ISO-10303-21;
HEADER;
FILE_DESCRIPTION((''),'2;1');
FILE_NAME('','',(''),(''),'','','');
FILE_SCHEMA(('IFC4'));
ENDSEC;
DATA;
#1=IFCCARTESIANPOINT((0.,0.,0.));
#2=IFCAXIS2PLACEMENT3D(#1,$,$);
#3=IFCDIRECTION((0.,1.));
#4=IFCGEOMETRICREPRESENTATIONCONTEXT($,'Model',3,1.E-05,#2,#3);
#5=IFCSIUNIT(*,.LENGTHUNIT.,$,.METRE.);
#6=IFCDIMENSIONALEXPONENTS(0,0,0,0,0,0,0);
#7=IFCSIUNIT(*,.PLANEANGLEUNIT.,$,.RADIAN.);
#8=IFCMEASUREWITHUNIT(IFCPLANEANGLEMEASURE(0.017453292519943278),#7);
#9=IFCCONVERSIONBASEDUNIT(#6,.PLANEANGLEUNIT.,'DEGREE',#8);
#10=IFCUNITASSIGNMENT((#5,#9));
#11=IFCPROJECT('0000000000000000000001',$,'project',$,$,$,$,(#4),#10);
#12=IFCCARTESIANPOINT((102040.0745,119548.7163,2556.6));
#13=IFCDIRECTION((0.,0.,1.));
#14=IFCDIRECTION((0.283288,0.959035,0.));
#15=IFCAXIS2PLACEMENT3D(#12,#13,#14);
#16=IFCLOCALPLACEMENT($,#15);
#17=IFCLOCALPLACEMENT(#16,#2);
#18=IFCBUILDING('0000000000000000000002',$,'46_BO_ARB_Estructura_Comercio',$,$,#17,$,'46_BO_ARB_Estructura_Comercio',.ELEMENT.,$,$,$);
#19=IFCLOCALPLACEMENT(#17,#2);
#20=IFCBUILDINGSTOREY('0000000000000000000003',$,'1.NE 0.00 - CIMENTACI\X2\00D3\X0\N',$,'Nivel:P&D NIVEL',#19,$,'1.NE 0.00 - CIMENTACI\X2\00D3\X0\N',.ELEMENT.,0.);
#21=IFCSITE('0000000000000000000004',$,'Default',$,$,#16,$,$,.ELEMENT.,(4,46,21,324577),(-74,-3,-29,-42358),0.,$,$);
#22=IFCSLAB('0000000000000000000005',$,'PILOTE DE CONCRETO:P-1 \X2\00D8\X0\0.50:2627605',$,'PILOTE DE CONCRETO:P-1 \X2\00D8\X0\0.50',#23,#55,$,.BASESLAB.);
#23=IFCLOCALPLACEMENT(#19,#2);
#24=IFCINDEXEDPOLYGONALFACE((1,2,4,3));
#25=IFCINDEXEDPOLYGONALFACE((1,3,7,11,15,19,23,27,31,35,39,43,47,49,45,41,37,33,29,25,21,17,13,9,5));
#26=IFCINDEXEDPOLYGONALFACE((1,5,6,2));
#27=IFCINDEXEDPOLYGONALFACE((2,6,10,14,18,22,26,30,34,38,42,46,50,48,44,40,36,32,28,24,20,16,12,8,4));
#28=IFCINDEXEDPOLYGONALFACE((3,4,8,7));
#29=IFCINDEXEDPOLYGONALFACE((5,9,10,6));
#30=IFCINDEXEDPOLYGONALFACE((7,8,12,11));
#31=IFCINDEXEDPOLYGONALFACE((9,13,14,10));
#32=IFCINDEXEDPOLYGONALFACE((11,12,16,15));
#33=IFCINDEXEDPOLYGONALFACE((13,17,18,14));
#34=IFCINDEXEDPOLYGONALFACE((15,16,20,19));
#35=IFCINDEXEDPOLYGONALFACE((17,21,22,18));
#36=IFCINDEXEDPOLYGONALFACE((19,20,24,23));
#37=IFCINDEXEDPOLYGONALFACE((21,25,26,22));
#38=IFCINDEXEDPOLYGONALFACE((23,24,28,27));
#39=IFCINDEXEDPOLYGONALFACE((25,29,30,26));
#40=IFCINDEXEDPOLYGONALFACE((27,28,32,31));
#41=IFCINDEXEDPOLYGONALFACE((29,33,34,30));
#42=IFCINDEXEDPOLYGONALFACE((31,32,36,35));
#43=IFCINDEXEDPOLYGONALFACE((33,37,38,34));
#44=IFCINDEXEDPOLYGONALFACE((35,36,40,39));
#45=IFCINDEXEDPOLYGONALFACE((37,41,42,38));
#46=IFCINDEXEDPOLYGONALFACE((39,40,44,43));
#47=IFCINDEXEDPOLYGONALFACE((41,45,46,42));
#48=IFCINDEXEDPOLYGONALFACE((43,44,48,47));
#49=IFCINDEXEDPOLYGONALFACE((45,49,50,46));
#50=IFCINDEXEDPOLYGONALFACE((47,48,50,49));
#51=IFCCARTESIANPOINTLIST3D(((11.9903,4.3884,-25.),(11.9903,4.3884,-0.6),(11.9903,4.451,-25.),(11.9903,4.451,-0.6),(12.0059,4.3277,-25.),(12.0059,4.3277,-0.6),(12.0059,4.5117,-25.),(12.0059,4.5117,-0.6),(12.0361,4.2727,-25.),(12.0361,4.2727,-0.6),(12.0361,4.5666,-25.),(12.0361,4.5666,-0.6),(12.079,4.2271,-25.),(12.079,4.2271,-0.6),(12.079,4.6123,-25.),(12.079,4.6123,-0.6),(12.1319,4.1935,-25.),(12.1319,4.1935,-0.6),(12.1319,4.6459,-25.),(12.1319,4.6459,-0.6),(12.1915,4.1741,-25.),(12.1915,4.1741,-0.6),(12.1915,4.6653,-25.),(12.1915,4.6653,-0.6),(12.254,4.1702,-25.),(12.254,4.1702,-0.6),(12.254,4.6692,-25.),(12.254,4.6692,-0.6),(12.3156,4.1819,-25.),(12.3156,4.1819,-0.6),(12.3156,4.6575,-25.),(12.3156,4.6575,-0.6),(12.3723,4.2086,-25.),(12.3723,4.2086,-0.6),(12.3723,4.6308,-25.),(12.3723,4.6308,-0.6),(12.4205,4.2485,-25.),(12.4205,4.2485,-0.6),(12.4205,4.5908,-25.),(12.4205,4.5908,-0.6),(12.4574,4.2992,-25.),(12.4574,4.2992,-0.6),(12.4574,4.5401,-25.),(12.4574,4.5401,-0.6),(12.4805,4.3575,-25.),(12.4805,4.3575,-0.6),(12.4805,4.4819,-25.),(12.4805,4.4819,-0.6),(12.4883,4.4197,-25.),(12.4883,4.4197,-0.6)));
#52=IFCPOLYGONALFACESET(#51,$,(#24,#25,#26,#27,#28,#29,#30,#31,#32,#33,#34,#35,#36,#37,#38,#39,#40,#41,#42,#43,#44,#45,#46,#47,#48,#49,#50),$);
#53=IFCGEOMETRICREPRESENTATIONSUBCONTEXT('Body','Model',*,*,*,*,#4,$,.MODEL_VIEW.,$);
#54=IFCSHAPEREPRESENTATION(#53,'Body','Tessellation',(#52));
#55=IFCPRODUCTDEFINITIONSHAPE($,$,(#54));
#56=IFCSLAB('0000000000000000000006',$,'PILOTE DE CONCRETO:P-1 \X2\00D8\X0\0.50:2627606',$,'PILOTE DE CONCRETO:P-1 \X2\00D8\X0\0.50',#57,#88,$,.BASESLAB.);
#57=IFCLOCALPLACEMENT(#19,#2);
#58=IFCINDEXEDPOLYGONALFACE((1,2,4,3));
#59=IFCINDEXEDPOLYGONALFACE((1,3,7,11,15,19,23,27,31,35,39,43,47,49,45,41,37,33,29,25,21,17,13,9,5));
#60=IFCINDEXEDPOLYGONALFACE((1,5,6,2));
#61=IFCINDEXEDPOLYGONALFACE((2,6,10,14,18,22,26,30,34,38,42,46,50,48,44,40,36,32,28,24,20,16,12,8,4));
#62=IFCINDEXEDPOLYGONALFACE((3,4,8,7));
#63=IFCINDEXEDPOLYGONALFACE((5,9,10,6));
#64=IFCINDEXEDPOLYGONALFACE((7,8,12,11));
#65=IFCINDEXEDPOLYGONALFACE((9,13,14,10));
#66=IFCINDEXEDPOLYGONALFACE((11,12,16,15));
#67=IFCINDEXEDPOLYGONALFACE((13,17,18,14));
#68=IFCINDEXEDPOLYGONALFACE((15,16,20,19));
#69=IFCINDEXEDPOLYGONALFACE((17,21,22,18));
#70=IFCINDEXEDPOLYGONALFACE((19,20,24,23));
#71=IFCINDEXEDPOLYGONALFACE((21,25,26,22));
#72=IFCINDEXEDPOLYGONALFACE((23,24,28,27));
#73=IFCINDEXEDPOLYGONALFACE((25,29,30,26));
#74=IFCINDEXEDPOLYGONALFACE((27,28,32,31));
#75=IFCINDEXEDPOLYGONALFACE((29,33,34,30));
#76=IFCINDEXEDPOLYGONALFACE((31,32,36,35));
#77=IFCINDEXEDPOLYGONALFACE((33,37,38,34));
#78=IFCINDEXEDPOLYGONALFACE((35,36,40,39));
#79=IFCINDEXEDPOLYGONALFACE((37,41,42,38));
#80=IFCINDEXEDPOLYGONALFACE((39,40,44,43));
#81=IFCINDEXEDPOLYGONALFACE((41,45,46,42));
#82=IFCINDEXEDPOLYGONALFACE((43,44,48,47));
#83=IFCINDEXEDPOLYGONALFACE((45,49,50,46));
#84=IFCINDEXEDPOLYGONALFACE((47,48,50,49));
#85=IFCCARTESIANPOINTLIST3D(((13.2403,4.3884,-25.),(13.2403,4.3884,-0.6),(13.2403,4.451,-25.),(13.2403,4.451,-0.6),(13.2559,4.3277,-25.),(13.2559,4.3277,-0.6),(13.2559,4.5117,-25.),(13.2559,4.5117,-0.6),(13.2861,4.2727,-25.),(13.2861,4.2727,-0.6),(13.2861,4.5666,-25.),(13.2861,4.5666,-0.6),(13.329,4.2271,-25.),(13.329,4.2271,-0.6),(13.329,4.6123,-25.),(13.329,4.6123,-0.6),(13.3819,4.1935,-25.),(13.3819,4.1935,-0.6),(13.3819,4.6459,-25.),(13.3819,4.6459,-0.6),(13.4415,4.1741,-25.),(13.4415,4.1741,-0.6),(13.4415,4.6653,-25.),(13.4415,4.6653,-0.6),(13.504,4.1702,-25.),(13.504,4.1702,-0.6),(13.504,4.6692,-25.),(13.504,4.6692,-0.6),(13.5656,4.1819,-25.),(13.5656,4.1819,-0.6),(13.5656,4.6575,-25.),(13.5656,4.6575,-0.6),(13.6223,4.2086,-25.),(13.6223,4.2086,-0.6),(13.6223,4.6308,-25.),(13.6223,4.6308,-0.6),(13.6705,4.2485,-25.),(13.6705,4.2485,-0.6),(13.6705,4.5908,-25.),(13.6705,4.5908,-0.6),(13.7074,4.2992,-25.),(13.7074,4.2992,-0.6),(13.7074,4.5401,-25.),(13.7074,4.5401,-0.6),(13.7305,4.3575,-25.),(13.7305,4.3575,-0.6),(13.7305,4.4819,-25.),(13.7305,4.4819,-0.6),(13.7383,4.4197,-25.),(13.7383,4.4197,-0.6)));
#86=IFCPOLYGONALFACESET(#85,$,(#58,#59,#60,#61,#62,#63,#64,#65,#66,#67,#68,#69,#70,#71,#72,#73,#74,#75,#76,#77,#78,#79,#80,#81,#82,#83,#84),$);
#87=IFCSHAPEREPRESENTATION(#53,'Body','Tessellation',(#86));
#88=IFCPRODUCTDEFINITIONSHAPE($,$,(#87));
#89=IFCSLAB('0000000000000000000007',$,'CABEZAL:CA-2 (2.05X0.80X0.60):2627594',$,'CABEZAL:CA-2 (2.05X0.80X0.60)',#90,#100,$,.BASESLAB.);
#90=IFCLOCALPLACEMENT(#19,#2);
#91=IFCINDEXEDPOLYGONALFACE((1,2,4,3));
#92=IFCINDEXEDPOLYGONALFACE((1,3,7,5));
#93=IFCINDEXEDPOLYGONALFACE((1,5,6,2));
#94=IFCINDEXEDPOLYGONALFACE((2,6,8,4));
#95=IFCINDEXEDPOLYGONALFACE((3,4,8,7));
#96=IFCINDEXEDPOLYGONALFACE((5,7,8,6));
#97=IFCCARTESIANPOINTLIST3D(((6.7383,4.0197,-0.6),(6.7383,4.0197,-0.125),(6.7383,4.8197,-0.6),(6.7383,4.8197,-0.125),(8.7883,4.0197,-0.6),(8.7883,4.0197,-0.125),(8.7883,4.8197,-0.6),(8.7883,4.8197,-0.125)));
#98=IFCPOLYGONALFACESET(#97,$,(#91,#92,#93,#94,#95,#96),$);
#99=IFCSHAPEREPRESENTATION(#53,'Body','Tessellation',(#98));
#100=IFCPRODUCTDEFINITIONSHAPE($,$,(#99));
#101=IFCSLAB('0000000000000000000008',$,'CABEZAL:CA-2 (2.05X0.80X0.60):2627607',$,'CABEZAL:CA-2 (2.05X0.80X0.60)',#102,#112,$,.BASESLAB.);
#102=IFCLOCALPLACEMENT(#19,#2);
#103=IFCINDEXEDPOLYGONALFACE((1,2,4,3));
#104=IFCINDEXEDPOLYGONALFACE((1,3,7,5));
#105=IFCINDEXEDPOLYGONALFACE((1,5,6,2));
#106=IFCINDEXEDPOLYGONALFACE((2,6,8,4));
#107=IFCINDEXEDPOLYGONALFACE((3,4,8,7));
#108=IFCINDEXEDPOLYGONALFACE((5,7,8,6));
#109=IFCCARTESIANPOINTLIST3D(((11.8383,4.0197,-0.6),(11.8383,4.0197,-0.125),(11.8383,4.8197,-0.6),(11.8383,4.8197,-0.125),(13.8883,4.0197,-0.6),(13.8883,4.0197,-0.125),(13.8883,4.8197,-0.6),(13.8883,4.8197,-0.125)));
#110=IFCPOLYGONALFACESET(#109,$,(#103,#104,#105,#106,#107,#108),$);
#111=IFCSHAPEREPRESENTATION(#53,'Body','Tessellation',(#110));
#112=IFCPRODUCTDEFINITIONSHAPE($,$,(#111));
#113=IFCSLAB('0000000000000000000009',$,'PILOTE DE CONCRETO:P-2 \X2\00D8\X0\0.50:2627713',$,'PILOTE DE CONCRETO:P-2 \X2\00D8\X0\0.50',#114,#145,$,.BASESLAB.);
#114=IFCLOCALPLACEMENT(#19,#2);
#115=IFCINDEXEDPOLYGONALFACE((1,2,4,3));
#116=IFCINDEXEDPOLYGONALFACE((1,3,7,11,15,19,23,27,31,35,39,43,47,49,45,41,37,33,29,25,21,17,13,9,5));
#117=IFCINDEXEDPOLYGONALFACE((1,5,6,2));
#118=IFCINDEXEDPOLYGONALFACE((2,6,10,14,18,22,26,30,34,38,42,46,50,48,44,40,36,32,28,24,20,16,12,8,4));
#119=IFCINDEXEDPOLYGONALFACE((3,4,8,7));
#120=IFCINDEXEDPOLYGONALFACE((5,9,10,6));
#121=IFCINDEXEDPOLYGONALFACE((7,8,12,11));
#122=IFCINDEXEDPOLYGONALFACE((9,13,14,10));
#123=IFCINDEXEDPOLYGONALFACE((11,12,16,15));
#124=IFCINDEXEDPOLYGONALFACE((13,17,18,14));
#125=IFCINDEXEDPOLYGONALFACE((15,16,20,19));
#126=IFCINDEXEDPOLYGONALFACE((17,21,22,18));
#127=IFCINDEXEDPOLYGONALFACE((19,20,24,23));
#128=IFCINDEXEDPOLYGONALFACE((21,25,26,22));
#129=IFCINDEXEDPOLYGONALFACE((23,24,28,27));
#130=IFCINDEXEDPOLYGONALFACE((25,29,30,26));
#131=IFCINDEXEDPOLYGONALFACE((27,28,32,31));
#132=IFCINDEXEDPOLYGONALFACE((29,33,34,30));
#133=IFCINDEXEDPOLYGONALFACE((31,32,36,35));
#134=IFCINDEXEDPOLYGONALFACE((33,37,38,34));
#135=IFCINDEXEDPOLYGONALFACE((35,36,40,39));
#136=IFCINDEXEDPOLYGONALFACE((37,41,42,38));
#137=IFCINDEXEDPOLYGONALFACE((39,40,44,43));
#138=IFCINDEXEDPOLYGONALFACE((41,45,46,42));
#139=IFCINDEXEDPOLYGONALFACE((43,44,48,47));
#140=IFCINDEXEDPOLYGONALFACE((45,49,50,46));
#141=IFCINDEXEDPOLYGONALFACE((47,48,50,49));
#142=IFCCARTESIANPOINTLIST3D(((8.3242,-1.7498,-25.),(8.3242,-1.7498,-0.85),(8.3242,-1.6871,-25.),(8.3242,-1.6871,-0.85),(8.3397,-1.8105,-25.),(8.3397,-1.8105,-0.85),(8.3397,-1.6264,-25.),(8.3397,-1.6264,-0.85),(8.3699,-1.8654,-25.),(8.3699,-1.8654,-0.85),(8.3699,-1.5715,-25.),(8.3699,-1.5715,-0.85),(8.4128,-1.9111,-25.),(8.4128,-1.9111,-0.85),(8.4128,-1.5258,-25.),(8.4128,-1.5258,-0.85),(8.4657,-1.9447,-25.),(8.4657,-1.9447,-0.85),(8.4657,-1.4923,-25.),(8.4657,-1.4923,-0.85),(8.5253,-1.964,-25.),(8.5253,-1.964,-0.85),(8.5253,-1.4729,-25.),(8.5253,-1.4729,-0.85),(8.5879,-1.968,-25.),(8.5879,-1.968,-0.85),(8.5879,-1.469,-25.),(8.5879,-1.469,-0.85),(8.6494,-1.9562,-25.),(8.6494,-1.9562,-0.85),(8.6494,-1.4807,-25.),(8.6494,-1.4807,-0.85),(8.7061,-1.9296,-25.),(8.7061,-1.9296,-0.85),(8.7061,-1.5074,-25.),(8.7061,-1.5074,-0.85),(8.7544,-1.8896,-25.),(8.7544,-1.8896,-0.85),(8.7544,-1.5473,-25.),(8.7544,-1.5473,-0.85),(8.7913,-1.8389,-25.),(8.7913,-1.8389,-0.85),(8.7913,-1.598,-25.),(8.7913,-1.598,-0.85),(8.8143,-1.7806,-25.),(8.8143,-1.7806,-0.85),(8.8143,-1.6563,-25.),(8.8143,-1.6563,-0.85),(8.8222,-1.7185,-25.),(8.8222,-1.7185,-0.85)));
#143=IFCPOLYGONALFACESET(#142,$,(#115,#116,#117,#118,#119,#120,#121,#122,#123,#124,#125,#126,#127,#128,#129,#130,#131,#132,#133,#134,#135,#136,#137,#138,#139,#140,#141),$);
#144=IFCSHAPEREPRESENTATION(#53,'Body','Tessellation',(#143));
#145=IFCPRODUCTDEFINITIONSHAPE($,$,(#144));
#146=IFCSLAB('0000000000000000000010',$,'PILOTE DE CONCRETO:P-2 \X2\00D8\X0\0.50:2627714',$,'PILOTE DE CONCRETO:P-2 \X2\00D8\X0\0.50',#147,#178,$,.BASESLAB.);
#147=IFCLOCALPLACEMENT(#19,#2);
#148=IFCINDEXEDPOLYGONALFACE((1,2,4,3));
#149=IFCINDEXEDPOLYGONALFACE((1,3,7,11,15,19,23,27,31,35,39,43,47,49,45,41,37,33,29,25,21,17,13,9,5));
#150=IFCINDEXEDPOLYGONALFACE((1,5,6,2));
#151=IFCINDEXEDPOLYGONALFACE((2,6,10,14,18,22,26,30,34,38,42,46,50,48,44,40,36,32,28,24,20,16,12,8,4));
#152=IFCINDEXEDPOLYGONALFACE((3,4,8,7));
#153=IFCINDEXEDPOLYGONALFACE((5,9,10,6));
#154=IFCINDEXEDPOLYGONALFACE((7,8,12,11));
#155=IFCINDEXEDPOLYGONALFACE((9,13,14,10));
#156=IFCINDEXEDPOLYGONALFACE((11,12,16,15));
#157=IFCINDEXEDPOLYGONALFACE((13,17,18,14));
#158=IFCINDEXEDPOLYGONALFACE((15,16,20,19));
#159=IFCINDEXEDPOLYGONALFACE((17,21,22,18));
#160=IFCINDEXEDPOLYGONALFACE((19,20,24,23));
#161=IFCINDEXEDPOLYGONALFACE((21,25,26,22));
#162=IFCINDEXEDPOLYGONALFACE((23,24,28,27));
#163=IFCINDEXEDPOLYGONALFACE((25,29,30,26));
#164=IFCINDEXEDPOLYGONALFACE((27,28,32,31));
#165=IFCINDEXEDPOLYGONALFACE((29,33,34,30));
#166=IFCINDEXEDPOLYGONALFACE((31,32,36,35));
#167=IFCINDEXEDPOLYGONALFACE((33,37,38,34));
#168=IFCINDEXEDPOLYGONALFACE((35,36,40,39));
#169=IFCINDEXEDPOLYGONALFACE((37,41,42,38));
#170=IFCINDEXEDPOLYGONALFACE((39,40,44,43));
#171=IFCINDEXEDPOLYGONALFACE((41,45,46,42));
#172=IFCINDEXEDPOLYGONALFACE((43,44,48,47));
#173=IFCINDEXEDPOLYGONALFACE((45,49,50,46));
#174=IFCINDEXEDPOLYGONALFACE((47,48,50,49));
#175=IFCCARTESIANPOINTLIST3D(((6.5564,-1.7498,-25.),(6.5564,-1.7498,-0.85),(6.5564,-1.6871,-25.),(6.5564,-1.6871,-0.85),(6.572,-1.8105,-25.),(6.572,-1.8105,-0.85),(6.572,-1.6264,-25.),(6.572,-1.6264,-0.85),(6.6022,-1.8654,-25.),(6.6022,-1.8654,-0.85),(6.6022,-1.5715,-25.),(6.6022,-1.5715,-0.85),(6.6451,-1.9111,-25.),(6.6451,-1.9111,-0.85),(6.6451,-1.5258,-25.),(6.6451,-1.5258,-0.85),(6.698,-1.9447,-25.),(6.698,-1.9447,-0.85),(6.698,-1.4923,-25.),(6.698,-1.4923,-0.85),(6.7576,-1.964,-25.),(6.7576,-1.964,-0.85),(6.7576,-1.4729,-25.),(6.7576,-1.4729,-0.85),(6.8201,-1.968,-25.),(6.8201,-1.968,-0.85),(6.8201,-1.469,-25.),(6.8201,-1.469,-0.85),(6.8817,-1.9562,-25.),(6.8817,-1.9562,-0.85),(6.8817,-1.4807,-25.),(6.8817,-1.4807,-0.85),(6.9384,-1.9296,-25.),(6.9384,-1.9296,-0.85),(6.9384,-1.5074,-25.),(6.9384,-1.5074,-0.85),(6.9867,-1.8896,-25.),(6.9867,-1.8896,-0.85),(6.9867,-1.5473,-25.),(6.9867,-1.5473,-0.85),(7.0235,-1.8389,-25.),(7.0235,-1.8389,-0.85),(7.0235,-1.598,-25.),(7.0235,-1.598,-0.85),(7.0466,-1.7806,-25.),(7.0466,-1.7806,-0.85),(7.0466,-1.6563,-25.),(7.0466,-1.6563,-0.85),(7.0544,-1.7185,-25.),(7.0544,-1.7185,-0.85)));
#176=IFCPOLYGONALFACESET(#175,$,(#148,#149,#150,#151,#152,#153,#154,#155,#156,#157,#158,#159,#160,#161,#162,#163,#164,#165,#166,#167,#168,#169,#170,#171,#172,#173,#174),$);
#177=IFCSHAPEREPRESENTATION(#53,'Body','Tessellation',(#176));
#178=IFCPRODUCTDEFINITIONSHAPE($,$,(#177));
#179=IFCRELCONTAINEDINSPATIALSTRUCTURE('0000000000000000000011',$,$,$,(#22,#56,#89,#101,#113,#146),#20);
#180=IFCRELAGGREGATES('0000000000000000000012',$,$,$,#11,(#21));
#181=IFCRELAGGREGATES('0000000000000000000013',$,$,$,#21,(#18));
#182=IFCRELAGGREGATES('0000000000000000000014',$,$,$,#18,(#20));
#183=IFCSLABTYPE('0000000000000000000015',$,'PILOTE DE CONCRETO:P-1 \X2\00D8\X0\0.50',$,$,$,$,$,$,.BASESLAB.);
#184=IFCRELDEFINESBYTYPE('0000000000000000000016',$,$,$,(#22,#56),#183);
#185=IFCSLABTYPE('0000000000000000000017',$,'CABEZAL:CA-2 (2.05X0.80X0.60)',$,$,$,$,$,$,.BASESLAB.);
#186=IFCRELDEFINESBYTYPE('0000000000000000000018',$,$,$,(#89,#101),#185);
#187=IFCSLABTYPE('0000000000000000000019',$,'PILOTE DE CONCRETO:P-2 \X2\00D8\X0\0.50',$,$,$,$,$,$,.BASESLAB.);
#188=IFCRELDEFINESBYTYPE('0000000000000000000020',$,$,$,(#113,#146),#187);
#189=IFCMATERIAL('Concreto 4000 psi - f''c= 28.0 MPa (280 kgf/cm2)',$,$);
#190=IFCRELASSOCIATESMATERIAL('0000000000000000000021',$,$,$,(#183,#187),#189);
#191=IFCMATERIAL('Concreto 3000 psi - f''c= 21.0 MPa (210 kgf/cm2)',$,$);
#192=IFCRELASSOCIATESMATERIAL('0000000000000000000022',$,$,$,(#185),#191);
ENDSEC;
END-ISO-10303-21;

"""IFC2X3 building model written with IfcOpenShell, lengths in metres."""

from ifc_helpers import new_model, entity, si_unit, converted_unit, direction, frame, frame_2d, origin, origin_2d_with_axis, place, context, subcontext, project, spatial, rectangle, circle, extrude, material, type_object, element, save


model = new_model("IFC2X3")

# Units and contexts
model_context = context("Model", 3, precision=1e-05, world=origin(), true_north=direction((0.0, 1.0)))
body_context = subcontext(model_context, "Body", "Model", "MODEL_VIEW")
ifc_project = project(units=[si_unit("LENGTHUNIT", "METRE"), converted_unit("PLANEANGLEUNIT", "DEGREE", entity("IfcPlaneAngleMeasure", 0.017453292519943278), si_unit("PLANEANGLEUNIT", "RADIAN"), dimensions=[0, 0, 0, 0, 0, 0, 0])], contexts=[model_context])

# Site, building, storey
site_placement = place(None, frame((102040.0745, 119548.7163, 2556.6), z_axis=(0.0, 0.0, 1.0), x_axis=(0.283288, 0.959035, 0.0)))
site = spatial("IfcSite", under=ifc_project, at=site_placement, Name="Default", CompositionType="ELEMENT", RefLatitude=(4, 46, 21, 324577), RefLongitude=(-74, -3, -29, -42358), RefElevation=0.0)
building_placement = place(site_placement, origin())
building = spatial("IfcBuilding", under=site, at=building_placement, Name="46_BO_ARB_Estructura_Comercio", LongName="46_BO_ARB_Estructura_Comercio", CompositionType="ELEMENT")
storey_placement = place(building_placement, origin())
storey = spatial("IfcBuildingStorey", under=building, at=storey_placement, Name="1.NE 0.00 - CIMENTACIÓN", ObjectType="Nivel:P&D NIVEL", LongName="1.NE 0.00 - CIMENTACIÓN", CompositionType="ELEMENT", Elevation=0.0)

# Shared definitions
ifc_material_1 = material(Name="Concreto 4000 psi - f'c= 28.0 MPa (280 kgf/cm2)")

# Shared definitions
ifc_material_2 = material(Name="Concreto 3000 psi - f'c= 21.0 MPa (210 kgf/cm2)")

# Slabs
slab_type_1 = type_object("IfcSlabType", Name="PILOTE DE CONCRETO:P-1 Ø0.50", PredefinedType="BASESLAB", material=ifc_material_1)
slab_1_placement = place(storey_placement, origin())
element("IfcSlab", 1, at=slab_1_placement, inside=storey, type_object=slab_type_1, Name="PILOTE DE CONCRETO:P-1 Ø0.50:2627605", ObjectType="PILOTE DE CONCRETO:P-1 Ø0.50", PredefinedType="BASESLAB", context=body_context, shape_type="SweptSolid", body=[
    extrude(circle(Radius=0.25, at=frame_2d((0.0, 0.0), x_axis=(1.0, 0.0))), frame((12.2383, 4.4197, -25.0)), (0.0, 0.0, 1.0), 24.4),
])
slab_2_placement = place(storey_placement, origin())
element("IfcSlab", 2, at=slab_2_placement, inside=storey, type_object=slab_type_1, Name="PILOTE DE CONCRETO:P-1 Ø0.50:2627606", ObjectType="PILOTE DE CONCRETO:P-1 Ø0.50", PredefinedType="BASESLAB", context=body_context, shape_type="SweptSolid", body=[
    extrude(circle(Radius=0.25, at=frame_2d((0.0, 0.0), x_axis=(1.0, 0.0))), frame((13.4883, 4.4197, -25.0)), (0.0, 0.0, 1.0), 24.4),
])
slab_type_2 = type_object("IfcSlabType", Name="CABEZAL:CA-2 (2.05X0.80X0.60)", PredefinedType="BASESLAB", material=ifc_material_2)
slab_3_placement = place(storey_placement, origin())
element("IfcSlab", 3, at=slab_3_placement, inside=storey, type_object=slab_type_2, Name="CABEZAL:CA-2 (2.05X0.80X0.60):2627594", ObjectType="CABEZAL:CA-2 (2.05X0.80X0.60)", PredefinedType="BASESLAB", context=body_context, shape_type="SweptSolid", body=[
    extrude(rectangle(XDim=2.05, YDim=0.8, at=origin_2d_with_axis()), frame((7.7633, 4.4197, -0.6), z_axis=(0.0, 0.0, 1.0), x_axis=(-1.0, 0.0, 0.0)), (0.0, 0.0, 1.0), 0.475),
])
slab_4_placement = place(storey_placement, origin())
element("IfcSlab", 4, at=slab_4_placement, inside=storey, type_object=slab_type_2, Name="CABEZAL:CA-2 (2.05X0.80X0.60):2627607", ObjectType="CABEZAL:CA-2 (2.05X0.80X0.60)", PredefinedType="BASESLAB", context=body_context, shape_type="SweptSolid", body=[
    extrude(rectangle(XDim=2.05, YDim=0.8, at=frame_2d((0.0, 0.0), x_axis=(1.0, 0.0))), frame((12.8633, 4.4197, -0.6), z_axis=(0.0, 0.0, 1.0), x_axis=(-1.0, 0.0, 0.0)), (0.0, 0.0, 1.0), 0.475),
])
slab_type_3 = type_object("IfcSlabType", Name="PILOTE DE CONCRETO:P-2 Ø0.50", PredefinedType="BASESLAB", material=ifc_material_1)
slab_5_placement = place(storey_placement, origin())
element("IfcSlab", 5, at=slab_5_placement, inside=storey, type_object=slab_type_3, Name="PILOTE DE CONCRETO:P-2 Ø0.50:2627713", ObjectType="PILOTE DE CONCRETO:P-2 Ø0.50", PredefinedType="BASESLAB", context=body_context, shape_type="SweptSolid", body=[
    extrude(circle(Radius=0.25, at=frame_2d((0.0, 0.0), x_axis=(1.0, 0.0))), frame((8.5722, -1.7185, -25.0)), (0.0, 0.0, 1.0), 24.15),
])
slab_6_placement = place(storey_placement, origin())
element("IfcSlab", 6, at=slab_6_placement, inside=storey, type_object=slab_type_3, Name="PILOTE DE CONCRETO:P-2 Ø0.50:2627714", ObjectType="PILOTE DE CONCRETO:P-2 Ø0.50", PredefinedType="BASESLAB", context=body_context, shape_type="SweptSolid", body=[
    extrude(circle(Radius=0.25, at=frame_2d((0.0, 0.0), x_axis=(1.0, 0.0))), frame((6.8044, -1.7185, -25.0)), (0.0, 0.0, 1.0), 24.15),
])

save(model, "model.ifc")
